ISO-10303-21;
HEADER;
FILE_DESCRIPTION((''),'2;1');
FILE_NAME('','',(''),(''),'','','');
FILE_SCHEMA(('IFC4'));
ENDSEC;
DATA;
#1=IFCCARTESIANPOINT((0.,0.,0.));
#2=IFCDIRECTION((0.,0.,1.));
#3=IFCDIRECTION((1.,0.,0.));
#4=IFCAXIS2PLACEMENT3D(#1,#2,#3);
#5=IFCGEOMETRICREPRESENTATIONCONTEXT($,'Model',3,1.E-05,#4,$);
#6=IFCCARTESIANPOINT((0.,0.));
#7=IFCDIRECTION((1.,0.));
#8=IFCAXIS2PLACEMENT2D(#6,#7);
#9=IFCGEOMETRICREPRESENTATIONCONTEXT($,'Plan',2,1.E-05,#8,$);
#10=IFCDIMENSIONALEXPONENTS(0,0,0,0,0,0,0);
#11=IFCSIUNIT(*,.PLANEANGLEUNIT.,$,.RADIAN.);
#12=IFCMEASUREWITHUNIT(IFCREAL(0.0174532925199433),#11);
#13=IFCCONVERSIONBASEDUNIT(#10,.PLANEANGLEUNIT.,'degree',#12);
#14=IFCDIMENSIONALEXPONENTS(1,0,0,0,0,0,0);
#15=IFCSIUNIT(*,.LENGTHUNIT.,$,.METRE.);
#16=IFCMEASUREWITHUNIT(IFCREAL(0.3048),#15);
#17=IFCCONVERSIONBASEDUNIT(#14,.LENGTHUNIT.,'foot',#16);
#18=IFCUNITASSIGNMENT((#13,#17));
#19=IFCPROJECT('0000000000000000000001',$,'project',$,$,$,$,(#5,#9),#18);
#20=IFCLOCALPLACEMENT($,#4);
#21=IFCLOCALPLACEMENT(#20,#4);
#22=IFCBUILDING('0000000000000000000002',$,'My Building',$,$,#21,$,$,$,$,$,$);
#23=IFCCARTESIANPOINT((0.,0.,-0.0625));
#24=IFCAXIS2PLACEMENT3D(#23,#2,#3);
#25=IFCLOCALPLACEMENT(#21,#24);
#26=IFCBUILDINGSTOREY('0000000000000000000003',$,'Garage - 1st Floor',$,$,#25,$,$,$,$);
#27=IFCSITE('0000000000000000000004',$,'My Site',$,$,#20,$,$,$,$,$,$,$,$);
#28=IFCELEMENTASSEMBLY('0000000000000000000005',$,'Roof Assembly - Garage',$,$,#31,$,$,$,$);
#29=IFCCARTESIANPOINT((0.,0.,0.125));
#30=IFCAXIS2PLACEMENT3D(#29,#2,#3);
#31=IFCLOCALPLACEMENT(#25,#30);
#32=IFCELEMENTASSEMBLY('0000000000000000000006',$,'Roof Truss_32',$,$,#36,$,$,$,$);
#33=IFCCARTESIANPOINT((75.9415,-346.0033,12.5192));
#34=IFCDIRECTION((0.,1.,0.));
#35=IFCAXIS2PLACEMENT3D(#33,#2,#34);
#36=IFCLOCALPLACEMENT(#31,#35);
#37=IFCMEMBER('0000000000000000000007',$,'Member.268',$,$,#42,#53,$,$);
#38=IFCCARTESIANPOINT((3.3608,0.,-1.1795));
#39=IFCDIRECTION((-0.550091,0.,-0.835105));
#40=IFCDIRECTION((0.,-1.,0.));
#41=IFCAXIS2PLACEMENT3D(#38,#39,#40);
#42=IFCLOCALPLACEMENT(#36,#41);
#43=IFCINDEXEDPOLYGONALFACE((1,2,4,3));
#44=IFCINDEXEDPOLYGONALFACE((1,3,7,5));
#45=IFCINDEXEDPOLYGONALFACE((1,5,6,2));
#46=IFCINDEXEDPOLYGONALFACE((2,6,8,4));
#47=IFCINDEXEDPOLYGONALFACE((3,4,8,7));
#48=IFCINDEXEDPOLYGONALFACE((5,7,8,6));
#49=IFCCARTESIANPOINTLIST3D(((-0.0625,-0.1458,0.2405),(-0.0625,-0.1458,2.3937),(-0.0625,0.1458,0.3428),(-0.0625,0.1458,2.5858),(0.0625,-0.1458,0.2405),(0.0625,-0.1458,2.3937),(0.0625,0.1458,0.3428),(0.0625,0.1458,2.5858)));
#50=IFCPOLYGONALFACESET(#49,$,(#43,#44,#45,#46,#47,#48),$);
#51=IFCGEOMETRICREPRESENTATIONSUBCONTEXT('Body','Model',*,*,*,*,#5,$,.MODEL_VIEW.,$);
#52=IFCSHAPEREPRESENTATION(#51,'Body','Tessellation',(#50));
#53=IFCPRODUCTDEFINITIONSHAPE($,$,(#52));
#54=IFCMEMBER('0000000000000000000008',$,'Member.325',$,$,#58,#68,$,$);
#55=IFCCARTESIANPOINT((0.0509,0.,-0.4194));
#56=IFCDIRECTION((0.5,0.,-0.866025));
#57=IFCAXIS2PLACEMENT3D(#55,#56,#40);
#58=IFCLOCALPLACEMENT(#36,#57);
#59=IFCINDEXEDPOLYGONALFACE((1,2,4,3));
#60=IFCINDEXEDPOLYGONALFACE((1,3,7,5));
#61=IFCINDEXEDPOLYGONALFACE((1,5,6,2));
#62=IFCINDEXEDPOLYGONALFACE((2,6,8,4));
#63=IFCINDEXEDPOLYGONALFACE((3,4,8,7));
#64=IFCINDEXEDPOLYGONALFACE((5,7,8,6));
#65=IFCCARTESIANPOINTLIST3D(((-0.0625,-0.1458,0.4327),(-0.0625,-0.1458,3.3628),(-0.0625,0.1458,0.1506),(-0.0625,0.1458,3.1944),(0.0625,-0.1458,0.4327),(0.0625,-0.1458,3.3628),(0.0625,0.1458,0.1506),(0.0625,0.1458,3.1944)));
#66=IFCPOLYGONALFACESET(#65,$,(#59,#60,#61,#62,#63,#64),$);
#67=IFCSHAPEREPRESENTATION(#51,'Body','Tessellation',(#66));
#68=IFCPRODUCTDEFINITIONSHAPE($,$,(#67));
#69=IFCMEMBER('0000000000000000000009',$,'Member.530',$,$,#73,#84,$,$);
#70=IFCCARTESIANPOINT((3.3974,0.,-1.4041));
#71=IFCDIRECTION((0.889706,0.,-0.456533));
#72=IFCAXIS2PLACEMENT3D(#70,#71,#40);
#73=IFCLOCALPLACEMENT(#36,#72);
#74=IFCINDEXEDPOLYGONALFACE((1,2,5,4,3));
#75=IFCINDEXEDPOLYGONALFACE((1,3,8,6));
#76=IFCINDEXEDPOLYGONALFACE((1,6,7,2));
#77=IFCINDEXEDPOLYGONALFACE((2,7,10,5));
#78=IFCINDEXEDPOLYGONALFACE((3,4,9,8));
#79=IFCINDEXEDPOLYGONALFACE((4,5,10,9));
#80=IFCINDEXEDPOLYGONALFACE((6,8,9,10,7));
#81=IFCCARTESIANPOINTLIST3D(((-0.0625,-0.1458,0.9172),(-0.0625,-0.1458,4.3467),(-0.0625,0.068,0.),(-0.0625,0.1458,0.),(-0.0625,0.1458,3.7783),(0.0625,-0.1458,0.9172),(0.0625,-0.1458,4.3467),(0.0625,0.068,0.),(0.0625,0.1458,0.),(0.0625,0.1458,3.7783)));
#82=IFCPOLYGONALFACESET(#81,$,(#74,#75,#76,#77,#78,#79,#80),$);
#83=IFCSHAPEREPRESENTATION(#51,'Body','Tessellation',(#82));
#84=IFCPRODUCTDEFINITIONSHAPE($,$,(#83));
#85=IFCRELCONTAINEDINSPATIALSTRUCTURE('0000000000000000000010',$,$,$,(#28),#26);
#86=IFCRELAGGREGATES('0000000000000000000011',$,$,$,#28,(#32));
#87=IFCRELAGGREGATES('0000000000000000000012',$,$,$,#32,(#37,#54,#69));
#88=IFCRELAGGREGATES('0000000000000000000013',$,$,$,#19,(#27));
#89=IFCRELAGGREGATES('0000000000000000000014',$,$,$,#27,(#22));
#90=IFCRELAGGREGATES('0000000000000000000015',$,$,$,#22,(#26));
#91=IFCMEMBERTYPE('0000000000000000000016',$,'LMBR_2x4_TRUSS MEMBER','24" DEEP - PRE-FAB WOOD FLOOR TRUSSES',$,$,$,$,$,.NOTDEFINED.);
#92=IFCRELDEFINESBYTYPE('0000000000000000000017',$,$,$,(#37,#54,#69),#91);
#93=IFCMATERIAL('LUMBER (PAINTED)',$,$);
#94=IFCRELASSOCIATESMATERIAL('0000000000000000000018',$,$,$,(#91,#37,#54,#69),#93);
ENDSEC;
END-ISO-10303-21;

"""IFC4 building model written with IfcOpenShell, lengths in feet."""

from ifc_helpers import new_model, entity, si_unit, converted_unit, frame, origin_with_axes, origin_2d_with_axis, place, context, subcontext, project, spatial, indexed_curve, outline, extrude, clip, halfspace, material, material_profile, profile_set, profile_usage, type_object, element, aggregate, save


model = new_model("IFC4")

# Units and contexts
model_context = context("Model", 3, precision=1e-05, world=origin_with_axes())
plan_context = context("Plan", 2, precision=1e-05, world=origin_2d_with_axis())
body_context = subcontext(model_context, "Body", "Model", "MODEL_VIEW")
ifc_project = project(units=[converted_unit("PLANEANGLEUNIT", "degree", entity("IfcReal", 0.0174532925199433), si_unit("PLANEANGLEUNIT", "RADIAN"), dimensions=[0, 0, 0, 0, 0, 0, 0]), converted_unit("LENGTHUNIT", "foot", entity("IfcReal", 0.3048), si_unit("LENGTHUNIT", "METRE"), dimensions=[1, 0, 0, 0, 0, 0, 0])], contexts=[model_context, plan_context])

# Site, building, storey
site_placement = place(None, origin_with_axes())
site = spatial("IfcSite", under=ifc_project, at=site_placement, Name="My Site")
building_placement = place(site_placement, origin_with_axes())
building = spatial("IfcBuilding", under=site, at=building_placement, Name="My Building")
storey_placement = place(building_placement, frame((0.0, 0.0, -0.0625), z_axis=(0.0, 0.0, 1.0), x_axis=(1.0, 0.0, 0.0)))
storey = spatial("IfcBuildingStorey", under=building, at=storey_placement, Name="Garage - 1st Floor")

# Element assemblies, members
assembly_1_placement = place(storey_placement, frame((0.0, 0.0, 0.125), z_axis=(0.0, 0.0, 1.0), x_axis=(1.0, 0.0, 0.0)))
assembly_1 = element("IfcElementAssembly", 1, at=assembly_1_placement, inside=storey, Name="Roof Assembly - Garage")
ifc_material = material(Name="LUMBER (PAINTED)")
ifc_material_profile_1 = material_profile(ifc_material, outline(indexed_curve([(-0.0625, -0.1458), (0.0625, -0.1458), (0.0625, 0.1458), (-0.0625, 0.1458), (-0.0625, -0.1458)])))
ifc_profile_set_1 = profile_set([ifc_material_profile_1])
member_type_1 = type_object("IfcMemberType", Name="LMBR_2x4_TRUSS MEMBER", Description="24\" DEEP - PRE-FAB WOOD FLOOR TRUSSES", PredefinedType="NOTDEFINED", material=ifc_profile_set_1)
assembly_2_placement = place(assembly_1_placement, frame((75.9415, -346.0033, 12.5192), z_axis=(0.0, 0.0, 1.0), x_axis=(0.0, 1.0, 0.0)))
assembly_2 = element("IfcElementAssembly", 2, at=assembly_2_placement, Name="Roof Truss_32")
aggregate(assembly_1, [assembly_2])
ifc_profile_usage_1 = profile_usage(ifc_profile_set_1)
member_1_placement = place(assembly_2_placement, frame((3.3608, 0.0, -1.1795), z_axis=(-0.550091, 0.0, -0.835105), x_axis=(0.0, -1.0, 0.0)))
member_1 = element("IfcMember", 3, at=member_1_placement, type_object=member_type_1, material=ifc_profile_usage_1, Name="Member.268", context=body_context, shape_type="Clipping", body=[
    clip(clip(extrude(outline(indexed_curve([(-0.0625, -0.1458), (0.0625, -0.1458), (0.0625, 0.1458), (-0.0625, 0.1458), (-0.0625, -0.1458)])), origin_with_axes(), (0.0, 0.0, 1.0), 2.7814), halfspace(frame((0.0, 3.2555, 1.4338), z_axis=(0.0, 0.331062, -0.943609), x_axis=(1.0, 0.0, 0.0)), False)), halfspace(frame((0.0, -4.6352, -0.5634), z_axis=(0.0, -0.550091, 0.835105), x_axis=(-1.0, 0.0, 0.0)), False)),
])
ifc_profile_usage_2 = profile_usage(ifc_profile_set_1)
member_2_placement = place(assembly_2_placement, frame((0.0509, 0.0, -0.4194), z_axis=(0.5, 0.0, -0.866025), x_axis=(0.0, -1.0, 0.0)))
member_2 = element("IfcMember", 4, at=member_2_placement, type_object=member_type_1, material=ifc_profile_usage_2, Name="Member.325", context=body_context, shape_type="Clipping", body=[
    clip(clip(extrude(outline(indexed_curve([(-0.0625, -0.1458), (0.0625, -0.1458), (0.0625, 0.1458), (-0.0625, 0.1458), (-0.0625, -0.1458)])), origin_with_axes(), (0.0, 0.0, 1.0), 3.5703), halfspace(frame((0.0, -5.0674, 6.2043), z_axis=(0.0, 0.5, 0.866025), x_axis=(1.0, 0.0, 0.0)), False)), halfspace(frame((0.0, 0.2544, 0.0456), z_axis=(0.0, -0.695161, -0.718855), x_axis=(-1.0, 0.0, 0.0)), False)),
])
ifc_profile_usage_3 = profile_usage(ifc_profile_set_1)
member_3_placement = place(assembly_2_placement, frame((3.3974, 0.0, -1.4041), z_axis=(0.889706, 0.0, -0.456533), x_axis=(0.0, -1.0, 0.0)))
member_3 = element("IfcMember", 5, at=member_3_placement, type_object=member_type_1, material=ifc_profile_usage_3, Name="Member.530", context=body_context, shape_type="Clipping", body=[
    clip(clip(extrude(outline(indexed_curve([(-0.0625, -0.1458), (0.0625, -0.1458), (0.0625, 0.1458), (-0.0625, 0.1458), (-0.0625, -0.1458)])), origin_with_axes(), (0.0, 0.0, 1.0), 4.3542), halfspace(frame((0.0, -0.2419, 4.5339), z_axis=(0.0, 0.889707, 0.456533), x_axis=(1.0, 0.0, 0.0)), False)), halfspace(frame((0.0, 0.8902, -3.5265), z_axis=(0.0, -0.973882, -0.227053), x_axis=(-1.0, 0.0, 0.0)), False)),
])
aggregate(assembly_2, [member_1, member_2, member_3])

save(model, "model.ifc")
